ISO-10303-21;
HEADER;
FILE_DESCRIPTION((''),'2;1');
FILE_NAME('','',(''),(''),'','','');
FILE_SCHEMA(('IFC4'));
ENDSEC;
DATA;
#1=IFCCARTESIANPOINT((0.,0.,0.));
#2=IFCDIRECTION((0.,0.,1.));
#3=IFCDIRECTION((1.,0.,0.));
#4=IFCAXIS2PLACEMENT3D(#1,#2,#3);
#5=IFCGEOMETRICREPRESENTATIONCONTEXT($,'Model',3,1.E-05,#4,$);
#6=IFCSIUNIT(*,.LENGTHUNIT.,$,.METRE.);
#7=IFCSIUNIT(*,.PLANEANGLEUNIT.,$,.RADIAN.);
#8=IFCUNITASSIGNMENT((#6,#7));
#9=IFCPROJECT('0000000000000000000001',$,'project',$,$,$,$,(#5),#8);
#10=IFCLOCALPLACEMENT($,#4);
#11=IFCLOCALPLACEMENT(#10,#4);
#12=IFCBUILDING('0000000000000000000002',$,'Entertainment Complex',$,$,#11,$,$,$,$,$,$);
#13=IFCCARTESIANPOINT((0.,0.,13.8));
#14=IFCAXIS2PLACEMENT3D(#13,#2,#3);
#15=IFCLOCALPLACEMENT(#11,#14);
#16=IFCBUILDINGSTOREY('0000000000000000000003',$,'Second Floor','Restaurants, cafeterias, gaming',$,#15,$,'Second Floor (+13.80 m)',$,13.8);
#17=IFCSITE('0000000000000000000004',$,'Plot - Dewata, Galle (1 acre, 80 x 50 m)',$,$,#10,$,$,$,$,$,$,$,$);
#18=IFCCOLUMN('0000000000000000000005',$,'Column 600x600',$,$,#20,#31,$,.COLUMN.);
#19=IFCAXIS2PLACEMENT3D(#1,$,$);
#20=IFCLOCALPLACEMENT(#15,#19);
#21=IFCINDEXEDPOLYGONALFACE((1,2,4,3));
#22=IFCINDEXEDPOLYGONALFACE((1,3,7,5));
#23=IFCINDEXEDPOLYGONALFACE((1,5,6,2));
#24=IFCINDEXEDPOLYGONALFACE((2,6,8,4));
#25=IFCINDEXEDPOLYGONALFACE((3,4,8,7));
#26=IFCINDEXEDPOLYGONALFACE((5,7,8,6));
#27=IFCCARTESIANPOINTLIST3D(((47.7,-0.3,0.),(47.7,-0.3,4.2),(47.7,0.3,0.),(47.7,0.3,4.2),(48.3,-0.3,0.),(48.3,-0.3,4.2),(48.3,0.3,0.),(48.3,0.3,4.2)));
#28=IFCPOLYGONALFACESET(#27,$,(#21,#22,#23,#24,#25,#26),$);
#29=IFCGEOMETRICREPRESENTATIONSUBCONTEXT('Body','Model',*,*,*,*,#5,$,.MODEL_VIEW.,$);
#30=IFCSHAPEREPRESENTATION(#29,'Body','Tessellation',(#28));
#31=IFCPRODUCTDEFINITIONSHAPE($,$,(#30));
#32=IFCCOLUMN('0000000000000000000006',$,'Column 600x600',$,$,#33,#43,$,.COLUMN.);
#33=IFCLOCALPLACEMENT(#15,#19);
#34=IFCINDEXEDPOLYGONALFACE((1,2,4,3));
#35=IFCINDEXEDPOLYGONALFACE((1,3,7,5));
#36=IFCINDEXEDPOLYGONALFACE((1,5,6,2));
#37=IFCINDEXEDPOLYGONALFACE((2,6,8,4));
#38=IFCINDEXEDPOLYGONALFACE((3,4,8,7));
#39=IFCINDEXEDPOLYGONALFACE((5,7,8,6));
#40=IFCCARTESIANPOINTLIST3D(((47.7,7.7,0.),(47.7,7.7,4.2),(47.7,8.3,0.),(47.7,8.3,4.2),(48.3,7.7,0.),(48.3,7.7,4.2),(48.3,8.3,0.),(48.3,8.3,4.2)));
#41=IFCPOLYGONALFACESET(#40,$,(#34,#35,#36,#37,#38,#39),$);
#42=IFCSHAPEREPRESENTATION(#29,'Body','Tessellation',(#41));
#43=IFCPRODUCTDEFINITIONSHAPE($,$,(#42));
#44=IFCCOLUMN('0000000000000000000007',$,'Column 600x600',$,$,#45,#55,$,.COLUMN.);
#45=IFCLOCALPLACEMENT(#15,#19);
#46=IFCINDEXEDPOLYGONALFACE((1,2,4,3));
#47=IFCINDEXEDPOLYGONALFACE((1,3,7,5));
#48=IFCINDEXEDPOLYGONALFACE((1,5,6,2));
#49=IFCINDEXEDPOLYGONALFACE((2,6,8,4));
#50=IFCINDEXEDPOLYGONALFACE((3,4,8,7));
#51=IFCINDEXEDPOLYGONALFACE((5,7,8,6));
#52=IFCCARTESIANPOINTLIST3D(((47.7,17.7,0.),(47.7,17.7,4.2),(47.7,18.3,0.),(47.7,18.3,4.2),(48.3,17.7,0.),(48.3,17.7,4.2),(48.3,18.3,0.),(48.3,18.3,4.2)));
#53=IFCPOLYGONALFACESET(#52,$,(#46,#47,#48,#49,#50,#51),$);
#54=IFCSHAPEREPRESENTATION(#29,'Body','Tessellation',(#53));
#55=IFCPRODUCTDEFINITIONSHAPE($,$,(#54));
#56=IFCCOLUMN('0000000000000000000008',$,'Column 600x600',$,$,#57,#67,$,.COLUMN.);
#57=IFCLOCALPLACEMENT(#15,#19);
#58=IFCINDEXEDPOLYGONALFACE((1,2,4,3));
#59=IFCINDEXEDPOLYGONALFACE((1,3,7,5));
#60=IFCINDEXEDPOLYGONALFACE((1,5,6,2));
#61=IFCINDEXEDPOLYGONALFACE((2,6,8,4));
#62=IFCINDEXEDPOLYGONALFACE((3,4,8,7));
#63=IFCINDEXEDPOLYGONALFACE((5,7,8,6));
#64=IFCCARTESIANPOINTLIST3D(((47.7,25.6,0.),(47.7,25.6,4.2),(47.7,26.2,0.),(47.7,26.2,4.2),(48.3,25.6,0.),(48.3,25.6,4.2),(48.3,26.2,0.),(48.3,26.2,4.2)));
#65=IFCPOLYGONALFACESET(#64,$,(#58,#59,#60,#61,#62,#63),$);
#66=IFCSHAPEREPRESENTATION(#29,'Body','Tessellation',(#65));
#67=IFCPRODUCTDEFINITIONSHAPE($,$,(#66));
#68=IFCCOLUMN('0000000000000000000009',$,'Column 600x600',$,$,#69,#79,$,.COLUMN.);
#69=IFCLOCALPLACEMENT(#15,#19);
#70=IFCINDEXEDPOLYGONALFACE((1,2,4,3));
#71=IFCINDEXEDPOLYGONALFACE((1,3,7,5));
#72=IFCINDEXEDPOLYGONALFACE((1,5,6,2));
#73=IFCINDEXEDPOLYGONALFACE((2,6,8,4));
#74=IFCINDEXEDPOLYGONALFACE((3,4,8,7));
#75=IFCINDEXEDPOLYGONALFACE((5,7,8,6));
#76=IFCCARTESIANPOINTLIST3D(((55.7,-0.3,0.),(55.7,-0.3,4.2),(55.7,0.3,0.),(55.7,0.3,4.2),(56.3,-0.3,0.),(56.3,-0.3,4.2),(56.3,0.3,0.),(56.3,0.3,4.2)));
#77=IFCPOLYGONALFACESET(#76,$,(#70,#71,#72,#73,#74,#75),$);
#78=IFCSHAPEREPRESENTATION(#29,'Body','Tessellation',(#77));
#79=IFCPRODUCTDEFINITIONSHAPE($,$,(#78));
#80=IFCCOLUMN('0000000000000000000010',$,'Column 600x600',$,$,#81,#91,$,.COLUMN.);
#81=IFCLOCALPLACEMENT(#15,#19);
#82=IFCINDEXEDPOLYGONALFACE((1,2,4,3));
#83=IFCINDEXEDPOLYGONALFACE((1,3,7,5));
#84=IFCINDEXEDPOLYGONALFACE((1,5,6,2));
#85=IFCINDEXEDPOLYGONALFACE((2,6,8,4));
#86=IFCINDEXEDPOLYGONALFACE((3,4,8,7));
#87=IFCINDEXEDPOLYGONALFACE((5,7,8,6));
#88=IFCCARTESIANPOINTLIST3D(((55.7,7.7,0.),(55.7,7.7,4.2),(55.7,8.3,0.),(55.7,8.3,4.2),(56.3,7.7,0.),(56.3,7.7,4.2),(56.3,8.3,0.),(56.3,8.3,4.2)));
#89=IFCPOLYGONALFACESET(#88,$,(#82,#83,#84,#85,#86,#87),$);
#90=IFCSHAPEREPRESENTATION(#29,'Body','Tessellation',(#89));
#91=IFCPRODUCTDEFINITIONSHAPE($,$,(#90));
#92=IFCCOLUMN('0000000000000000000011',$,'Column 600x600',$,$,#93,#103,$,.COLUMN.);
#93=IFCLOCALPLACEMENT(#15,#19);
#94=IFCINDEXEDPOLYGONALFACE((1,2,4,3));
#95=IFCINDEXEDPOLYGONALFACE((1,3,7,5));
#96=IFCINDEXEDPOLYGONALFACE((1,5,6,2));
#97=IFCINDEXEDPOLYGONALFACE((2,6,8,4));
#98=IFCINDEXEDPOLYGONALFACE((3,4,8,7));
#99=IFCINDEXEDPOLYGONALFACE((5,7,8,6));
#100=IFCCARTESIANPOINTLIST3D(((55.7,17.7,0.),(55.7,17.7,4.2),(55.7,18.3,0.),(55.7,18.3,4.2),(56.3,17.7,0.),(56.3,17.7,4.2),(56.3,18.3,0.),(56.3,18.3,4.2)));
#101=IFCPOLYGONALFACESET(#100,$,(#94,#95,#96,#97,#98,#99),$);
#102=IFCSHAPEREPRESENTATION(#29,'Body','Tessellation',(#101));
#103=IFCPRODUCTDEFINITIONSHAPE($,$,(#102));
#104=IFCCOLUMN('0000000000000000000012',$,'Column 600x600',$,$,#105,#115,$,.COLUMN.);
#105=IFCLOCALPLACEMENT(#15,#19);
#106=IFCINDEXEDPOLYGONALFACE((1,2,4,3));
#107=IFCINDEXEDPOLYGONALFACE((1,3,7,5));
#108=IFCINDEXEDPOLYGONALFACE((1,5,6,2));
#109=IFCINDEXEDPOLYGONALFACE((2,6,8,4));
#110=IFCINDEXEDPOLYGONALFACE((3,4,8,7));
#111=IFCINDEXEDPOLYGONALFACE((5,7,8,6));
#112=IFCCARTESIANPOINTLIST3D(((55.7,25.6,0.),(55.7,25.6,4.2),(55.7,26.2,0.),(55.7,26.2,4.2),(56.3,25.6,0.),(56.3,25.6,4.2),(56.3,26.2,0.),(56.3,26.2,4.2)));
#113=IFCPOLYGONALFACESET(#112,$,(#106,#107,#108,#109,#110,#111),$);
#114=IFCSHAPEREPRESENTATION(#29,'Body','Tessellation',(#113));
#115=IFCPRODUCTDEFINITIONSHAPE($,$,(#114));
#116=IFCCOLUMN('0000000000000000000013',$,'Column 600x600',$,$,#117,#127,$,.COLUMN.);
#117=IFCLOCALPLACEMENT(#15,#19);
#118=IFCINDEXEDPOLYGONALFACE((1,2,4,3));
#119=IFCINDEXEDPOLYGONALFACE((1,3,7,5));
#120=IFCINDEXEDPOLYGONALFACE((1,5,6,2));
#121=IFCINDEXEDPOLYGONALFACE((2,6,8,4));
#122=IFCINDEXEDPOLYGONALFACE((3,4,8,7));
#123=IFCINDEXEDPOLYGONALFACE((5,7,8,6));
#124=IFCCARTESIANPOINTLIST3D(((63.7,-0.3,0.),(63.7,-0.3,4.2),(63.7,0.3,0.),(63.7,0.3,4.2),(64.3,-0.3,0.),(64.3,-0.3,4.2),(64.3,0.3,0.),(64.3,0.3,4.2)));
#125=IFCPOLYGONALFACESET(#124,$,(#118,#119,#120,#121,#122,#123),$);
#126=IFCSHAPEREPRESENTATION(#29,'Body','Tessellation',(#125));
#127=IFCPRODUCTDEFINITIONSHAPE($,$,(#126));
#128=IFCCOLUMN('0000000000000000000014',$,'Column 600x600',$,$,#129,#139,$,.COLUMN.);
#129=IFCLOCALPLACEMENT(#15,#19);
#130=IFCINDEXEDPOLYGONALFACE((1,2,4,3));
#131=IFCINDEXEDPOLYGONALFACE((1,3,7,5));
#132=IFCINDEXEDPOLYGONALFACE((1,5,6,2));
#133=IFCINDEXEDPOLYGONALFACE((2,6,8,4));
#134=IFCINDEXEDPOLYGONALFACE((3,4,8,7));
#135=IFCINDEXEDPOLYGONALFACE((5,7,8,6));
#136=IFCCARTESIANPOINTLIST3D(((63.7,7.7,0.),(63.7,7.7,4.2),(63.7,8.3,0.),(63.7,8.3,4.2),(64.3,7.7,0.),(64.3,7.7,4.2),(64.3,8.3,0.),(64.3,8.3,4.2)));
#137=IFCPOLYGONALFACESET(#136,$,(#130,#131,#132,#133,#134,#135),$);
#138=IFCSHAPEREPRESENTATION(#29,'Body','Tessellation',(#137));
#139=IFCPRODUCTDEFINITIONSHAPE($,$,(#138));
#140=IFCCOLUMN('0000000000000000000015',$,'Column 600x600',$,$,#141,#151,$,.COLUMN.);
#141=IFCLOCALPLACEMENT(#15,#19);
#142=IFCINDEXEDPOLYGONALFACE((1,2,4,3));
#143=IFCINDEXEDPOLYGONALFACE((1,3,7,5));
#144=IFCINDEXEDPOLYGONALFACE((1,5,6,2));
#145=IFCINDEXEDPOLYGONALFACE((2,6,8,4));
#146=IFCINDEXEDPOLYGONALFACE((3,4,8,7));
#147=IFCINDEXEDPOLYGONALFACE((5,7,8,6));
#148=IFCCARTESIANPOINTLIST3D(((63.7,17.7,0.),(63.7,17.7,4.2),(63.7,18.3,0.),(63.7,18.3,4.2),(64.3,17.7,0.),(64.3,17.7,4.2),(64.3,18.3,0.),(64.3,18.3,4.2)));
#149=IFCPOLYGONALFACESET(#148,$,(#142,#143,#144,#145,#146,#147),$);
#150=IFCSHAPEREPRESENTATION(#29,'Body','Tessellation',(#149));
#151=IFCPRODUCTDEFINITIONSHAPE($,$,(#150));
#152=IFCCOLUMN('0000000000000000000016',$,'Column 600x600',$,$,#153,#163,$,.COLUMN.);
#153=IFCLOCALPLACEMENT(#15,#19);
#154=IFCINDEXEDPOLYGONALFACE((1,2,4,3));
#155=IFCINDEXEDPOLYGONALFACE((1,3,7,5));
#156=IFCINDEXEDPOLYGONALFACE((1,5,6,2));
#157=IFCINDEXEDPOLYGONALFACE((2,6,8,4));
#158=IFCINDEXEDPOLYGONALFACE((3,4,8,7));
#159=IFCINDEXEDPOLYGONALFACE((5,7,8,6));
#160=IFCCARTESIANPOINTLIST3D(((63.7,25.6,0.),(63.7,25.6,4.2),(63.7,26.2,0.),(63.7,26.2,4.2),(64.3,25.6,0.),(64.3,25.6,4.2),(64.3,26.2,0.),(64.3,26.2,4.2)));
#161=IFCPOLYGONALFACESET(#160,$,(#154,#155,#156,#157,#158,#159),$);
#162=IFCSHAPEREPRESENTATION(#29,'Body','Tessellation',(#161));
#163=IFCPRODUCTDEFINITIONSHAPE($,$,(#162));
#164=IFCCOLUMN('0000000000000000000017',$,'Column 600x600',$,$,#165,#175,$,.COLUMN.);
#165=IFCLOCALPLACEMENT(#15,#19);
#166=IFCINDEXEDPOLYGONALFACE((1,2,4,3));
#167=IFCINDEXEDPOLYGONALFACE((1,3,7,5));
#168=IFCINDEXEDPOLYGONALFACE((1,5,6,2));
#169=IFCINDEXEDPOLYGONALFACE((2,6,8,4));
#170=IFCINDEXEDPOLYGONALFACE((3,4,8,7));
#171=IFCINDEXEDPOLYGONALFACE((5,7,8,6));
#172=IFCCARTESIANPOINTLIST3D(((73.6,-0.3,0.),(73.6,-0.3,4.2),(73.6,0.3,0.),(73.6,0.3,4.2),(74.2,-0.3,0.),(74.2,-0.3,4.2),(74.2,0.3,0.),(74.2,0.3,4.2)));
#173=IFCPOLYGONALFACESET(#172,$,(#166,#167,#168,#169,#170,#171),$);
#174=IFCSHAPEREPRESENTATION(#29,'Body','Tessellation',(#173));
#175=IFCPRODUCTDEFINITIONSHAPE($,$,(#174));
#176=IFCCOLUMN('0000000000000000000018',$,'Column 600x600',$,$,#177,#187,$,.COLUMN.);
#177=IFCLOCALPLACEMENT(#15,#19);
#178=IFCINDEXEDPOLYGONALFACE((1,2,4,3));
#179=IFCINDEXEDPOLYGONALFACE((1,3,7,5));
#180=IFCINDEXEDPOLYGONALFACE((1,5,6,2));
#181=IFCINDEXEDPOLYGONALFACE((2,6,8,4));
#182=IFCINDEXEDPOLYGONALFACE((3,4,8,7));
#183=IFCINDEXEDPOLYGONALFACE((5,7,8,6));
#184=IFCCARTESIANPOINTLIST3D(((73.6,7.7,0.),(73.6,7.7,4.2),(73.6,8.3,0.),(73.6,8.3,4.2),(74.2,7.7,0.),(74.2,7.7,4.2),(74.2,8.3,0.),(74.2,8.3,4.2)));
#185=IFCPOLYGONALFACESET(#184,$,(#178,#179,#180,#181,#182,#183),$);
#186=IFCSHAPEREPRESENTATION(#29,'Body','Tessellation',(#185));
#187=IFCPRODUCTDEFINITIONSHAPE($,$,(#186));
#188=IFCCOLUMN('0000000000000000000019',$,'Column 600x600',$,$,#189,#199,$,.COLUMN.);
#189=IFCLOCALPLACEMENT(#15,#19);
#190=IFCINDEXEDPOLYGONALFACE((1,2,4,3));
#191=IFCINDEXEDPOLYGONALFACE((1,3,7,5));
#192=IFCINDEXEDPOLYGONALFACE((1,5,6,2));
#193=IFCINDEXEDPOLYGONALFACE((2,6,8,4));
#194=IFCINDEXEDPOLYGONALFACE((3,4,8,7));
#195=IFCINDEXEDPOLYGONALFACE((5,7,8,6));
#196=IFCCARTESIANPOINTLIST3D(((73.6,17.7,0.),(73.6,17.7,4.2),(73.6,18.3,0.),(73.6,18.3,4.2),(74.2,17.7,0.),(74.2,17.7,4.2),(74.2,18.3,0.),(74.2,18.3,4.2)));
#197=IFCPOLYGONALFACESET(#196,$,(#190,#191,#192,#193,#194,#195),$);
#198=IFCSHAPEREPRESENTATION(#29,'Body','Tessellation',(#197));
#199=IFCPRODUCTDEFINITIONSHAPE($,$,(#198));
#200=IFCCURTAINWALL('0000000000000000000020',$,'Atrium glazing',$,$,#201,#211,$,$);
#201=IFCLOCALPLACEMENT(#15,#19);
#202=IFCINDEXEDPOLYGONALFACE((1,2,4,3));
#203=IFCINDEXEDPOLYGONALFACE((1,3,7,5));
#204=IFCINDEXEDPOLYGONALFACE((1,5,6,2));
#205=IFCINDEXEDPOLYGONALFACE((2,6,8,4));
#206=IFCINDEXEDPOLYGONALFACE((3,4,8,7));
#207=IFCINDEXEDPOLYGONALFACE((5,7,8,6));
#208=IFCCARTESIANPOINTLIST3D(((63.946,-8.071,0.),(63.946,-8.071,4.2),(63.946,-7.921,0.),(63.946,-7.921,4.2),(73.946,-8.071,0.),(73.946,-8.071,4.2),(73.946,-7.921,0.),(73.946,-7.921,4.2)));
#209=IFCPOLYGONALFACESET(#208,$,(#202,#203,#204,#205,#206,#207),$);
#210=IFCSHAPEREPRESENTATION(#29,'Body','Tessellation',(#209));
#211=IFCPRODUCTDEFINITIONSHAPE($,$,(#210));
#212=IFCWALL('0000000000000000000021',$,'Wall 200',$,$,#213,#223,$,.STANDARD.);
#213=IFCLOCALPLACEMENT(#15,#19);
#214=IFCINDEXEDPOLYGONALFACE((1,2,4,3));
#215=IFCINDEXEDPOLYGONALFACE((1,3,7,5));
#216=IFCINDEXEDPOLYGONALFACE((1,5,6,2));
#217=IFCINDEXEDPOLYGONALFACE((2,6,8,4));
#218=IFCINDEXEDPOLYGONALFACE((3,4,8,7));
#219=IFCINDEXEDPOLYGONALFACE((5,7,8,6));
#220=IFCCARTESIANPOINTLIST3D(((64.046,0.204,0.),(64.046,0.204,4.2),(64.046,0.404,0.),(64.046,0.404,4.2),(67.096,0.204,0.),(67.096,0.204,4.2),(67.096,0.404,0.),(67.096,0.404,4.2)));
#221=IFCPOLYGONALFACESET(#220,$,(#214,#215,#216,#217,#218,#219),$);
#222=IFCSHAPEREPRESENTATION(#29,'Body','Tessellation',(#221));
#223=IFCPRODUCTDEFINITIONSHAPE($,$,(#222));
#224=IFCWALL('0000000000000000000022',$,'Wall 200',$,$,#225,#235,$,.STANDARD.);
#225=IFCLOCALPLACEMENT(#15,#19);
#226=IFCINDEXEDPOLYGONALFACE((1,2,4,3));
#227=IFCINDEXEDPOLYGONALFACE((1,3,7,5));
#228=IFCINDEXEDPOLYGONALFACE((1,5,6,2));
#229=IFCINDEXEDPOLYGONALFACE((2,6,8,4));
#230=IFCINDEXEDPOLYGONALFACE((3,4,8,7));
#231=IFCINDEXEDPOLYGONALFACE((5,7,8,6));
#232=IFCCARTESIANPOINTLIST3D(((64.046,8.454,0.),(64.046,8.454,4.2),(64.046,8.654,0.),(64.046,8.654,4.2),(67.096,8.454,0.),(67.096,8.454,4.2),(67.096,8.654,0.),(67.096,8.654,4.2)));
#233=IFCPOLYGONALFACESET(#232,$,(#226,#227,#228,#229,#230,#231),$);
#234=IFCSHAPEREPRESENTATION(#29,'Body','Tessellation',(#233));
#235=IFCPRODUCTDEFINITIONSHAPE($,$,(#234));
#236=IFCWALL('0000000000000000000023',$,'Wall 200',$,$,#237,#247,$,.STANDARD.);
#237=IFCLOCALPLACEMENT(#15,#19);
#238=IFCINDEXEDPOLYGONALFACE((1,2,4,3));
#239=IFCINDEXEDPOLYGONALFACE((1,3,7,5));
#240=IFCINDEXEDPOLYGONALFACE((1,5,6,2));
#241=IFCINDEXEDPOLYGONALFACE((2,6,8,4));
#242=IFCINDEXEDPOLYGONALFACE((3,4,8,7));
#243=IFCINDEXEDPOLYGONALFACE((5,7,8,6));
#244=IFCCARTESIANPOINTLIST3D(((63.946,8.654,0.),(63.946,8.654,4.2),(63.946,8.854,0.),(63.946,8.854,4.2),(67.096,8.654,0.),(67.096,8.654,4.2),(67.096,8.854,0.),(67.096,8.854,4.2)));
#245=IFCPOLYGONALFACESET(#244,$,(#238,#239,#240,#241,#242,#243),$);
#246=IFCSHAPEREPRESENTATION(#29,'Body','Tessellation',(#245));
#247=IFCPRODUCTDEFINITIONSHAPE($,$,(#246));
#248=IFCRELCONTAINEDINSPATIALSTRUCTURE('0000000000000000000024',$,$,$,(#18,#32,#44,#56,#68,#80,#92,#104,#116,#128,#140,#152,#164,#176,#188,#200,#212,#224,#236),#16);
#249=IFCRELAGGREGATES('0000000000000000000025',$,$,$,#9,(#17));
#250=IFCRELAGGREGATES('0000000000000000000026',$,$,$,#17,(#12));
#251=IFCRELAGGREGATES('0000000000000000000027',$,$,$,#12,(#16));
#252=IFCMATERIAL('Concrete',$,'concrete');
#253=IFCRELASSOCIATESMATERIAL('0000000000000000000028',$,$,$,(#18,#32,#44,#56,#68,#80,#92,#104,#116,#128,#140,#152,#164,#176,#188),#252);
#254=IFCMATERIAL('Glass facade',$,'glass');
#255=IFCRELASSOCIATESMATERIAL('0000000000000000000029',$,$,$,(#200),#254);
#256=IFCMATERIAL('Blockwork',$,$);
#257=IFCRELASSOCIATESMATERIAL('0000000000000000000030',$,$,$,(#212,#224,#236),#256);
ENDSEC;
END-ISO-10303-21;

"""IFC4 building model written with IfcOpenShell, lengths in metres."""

from ifc_helpers import new_model, si_unit, frame, origin_with_axes, place, context, subcontext, project, spatial, polyline, outline, extrude, material, element, save


model = new_model("IFC4")

# Units and contexts
model_context = context("Model", 3, precision=1e-05, world=origin_with_axes())
body_context = subcontext(model_context, "Body", "Model", "MODEL_VIEW")
ifc_project = project(units=[si_unit("LENGTHUNIT", "METRE"), si_unit("PLANEANGLEUNIT", "RADIAN")], contexts=[model_context])

# Site, building, storey
site_placement = place(None, origin_with_axes())
site = spatial("IfcSite", under=ifc_project, at=site_placement, Name="Plot - Dewata, Galle (1 acre, 80 x 50 m)")
building_placement = place(site_placement, origin_with_axes())
building = spatial("IfcBuilding", under=site, at=building_placement, Name="Entertainment Complex")
storey_placement = place(building_placement, frame((0.0, 0.0, 13.8), z_axis=(0.0, 0.0, 1.0), x_axis=(1.0, 0.0, 0.0)))
storey = spatial("IfcBuildingStorey", under=building, at=storey_placement, Name="Second Floor", Description="Restaurants, cafeterias, gaming", LongName="Second Floor (+13.80 m)", Elevation=13.8)

# Columns
ifc_material_1 = material(Name="Concrete", Category="concrete")
for number, where, z_axis, x_axis, name in (
    (1, (48.0, 0.0, 0.0), (0.0, 0.0, 1.0), (1.0, 0.0, 0.0), "Column 600x600"),
    (2, (48.0, 8.0, 0.0), (0.0, 0.0, 1.0), (1.0, 0.0, 0.0), "Column 600x600"),
    (3, (48.0, 18.0, 0.0), (0.0, 0.0, 1.0), (1.0, 0.0, 0.0), "Column 600x600"),
    (4, (48.0, 25.9, 0.0), (0.0, 0.0, 1.0), (1.0, 0.0, 0.0), "Column 600x600"),
    (5, (56.0, 0.0, 0.0), (0.0, 0.0, 1.0), (1.0, 0.0, 0.0), "Column 600x600"),
    (6, (56.0, 8.0, 0.0), (0.0, 0.0, 1.0), (1.0, 0.0, 0.0), "Column 600x600"),
    (7, (56.0, 18.0, 0.0), (0.0, 0.0, 1.0), (1.0, 0.0, 0.0), "Column 600x600"),
    (8, (56.0, 25.9, 0.0), (0.0, 0.0, 1.0), (1.0, 0.0, 0.0), "Column 600x600"),
    (9, (64.0, 0.0, 0.0), (0.0, 0.0, 1.0), (1.0, 0.0, 0.0), "Column 600x600"),
    (10, (64.0, 8.0, 0.0), (0.0, 0.0, 1.0), (1.0, 0.0, 0.0), "Column 600x600"),
    (11, (64.0, 18.0, 0.0), (0.0, 0.0, 1.0), (1.0, 0.0, 0.0), "Column 600x600"),
    (12, (64.0, 25.9, 0.0), (0.0, 0.0, 1.0), (1.0, 0.0, 0.0), "Column 600x600"),
    (13, (73.9, 0.0, 0.0), (0.0, 0.0, 1.0), (1.0, 0.0, 0.0), "Column 600x600"),
    (14, (73.9, 8.0, 0.0), (0.0, 0.0, 1.0), (1.0, 0.0, 0.0), "Column 600x600"),
    (15, (73.9, 18.0, 0.0), (0.0, 0.0, 1.0), (1.0, 0.0, 0.0), "Column 600x600"),
):
    element("IfcColumn", number, at=place(storey_placement, frame(where, z_axis=z_axis, x_axis=x_axis)), inside=storey, material=ifc_material_1, Name=name, PredefinedType="COLUMN", context=body_context, shape_type="SweptSolid", body=[
        extrude(outline(polyline([(-0.3, -0.3), (0.3, -0.3), (0.3, 0.3), (-0.3, 0.3), (-0.3, -0.3)])), origin_with_axes(), (0.0, 0.0, 1.0), 4.2),
    ])

# Curtain wall
ifc_material_2 = material(Name="Glass facade", Category="glass")
curtain_wall_1_placement = place(storey_placement, frame((63.946, -7.996, 0.0), z_axis=(0.0, 0.0, 1.0), x_axis=(1.0, 0.0, 0.0)))
element("IfcCurtainWall", 16, at=curtain_wall_1_placement, inside=storey, material=ifc_material_2, Name="Atrium glazing", context=body_context, shape_type="SweptSolid", body=[
    extrude(outline(polyline([(0.0, -0.075), (10.0, -0.075), (10.0, 0.075), (0.0, 0.075), (0.0, -0.075)])), origin_with_axes(), (0.0, 0.0, 1.0), 4.2),
])

# Walls
ifc_material_3 = material(Name="Blockwork")
for number, where, z_axis, x_axis, name in (
    (17, (64.046, 0.304, 0.0), (0.0, 0.0, 1.0), (1.0, 0.0, 0.0), "Wall 200"),
    (18, (64.046, 8.554, 0.0), (0.0, 0.0, 1.0), (1.0, 0.0, 0.0), "Wall 200"),
):
    element("IfcWall", number, at=place(storey_placement, frame(where, z_axis=z_axis, x_axis=x_axis)), inside=storey, material=ifc_material_3, Name=name, PredefinedType="STANDARD", context=body_context, shape_type="SweptSolid", body=[
        extrude(outline(polyline([(0.0, -0.1), (3.05, -0.1), (3.05, 0.1), (0.0, 0.1), (0.0, -0.1)])), origin_with_axes(), (0.0, 0.0, 1.0), 4.2),
    ])
wall_1_placement = place(storey_placement, frame((63.946, 8.754, 0.0), z_axis=(0.0, 0.0, 1.0), x_axis=(1.0, 0.0, 0.0)))
element("IfcWall", 19, at=wall_1_placement, inside=storey, material=ifc_material_3, Name="Wall 200", PredefinedType="STANDARD", context=body_context, shape_type="SweptSolid", body=[
    extrude(outline(polyline([(0.0, -0.1), (3.15, -0.1), (3.15, 0.1), (0.0, 0.1), (0.0, -0.1)])), origin_with_axes(), (0.0, 0.0, 1.0), 4.2),
])

save(model, "model.ifc")
